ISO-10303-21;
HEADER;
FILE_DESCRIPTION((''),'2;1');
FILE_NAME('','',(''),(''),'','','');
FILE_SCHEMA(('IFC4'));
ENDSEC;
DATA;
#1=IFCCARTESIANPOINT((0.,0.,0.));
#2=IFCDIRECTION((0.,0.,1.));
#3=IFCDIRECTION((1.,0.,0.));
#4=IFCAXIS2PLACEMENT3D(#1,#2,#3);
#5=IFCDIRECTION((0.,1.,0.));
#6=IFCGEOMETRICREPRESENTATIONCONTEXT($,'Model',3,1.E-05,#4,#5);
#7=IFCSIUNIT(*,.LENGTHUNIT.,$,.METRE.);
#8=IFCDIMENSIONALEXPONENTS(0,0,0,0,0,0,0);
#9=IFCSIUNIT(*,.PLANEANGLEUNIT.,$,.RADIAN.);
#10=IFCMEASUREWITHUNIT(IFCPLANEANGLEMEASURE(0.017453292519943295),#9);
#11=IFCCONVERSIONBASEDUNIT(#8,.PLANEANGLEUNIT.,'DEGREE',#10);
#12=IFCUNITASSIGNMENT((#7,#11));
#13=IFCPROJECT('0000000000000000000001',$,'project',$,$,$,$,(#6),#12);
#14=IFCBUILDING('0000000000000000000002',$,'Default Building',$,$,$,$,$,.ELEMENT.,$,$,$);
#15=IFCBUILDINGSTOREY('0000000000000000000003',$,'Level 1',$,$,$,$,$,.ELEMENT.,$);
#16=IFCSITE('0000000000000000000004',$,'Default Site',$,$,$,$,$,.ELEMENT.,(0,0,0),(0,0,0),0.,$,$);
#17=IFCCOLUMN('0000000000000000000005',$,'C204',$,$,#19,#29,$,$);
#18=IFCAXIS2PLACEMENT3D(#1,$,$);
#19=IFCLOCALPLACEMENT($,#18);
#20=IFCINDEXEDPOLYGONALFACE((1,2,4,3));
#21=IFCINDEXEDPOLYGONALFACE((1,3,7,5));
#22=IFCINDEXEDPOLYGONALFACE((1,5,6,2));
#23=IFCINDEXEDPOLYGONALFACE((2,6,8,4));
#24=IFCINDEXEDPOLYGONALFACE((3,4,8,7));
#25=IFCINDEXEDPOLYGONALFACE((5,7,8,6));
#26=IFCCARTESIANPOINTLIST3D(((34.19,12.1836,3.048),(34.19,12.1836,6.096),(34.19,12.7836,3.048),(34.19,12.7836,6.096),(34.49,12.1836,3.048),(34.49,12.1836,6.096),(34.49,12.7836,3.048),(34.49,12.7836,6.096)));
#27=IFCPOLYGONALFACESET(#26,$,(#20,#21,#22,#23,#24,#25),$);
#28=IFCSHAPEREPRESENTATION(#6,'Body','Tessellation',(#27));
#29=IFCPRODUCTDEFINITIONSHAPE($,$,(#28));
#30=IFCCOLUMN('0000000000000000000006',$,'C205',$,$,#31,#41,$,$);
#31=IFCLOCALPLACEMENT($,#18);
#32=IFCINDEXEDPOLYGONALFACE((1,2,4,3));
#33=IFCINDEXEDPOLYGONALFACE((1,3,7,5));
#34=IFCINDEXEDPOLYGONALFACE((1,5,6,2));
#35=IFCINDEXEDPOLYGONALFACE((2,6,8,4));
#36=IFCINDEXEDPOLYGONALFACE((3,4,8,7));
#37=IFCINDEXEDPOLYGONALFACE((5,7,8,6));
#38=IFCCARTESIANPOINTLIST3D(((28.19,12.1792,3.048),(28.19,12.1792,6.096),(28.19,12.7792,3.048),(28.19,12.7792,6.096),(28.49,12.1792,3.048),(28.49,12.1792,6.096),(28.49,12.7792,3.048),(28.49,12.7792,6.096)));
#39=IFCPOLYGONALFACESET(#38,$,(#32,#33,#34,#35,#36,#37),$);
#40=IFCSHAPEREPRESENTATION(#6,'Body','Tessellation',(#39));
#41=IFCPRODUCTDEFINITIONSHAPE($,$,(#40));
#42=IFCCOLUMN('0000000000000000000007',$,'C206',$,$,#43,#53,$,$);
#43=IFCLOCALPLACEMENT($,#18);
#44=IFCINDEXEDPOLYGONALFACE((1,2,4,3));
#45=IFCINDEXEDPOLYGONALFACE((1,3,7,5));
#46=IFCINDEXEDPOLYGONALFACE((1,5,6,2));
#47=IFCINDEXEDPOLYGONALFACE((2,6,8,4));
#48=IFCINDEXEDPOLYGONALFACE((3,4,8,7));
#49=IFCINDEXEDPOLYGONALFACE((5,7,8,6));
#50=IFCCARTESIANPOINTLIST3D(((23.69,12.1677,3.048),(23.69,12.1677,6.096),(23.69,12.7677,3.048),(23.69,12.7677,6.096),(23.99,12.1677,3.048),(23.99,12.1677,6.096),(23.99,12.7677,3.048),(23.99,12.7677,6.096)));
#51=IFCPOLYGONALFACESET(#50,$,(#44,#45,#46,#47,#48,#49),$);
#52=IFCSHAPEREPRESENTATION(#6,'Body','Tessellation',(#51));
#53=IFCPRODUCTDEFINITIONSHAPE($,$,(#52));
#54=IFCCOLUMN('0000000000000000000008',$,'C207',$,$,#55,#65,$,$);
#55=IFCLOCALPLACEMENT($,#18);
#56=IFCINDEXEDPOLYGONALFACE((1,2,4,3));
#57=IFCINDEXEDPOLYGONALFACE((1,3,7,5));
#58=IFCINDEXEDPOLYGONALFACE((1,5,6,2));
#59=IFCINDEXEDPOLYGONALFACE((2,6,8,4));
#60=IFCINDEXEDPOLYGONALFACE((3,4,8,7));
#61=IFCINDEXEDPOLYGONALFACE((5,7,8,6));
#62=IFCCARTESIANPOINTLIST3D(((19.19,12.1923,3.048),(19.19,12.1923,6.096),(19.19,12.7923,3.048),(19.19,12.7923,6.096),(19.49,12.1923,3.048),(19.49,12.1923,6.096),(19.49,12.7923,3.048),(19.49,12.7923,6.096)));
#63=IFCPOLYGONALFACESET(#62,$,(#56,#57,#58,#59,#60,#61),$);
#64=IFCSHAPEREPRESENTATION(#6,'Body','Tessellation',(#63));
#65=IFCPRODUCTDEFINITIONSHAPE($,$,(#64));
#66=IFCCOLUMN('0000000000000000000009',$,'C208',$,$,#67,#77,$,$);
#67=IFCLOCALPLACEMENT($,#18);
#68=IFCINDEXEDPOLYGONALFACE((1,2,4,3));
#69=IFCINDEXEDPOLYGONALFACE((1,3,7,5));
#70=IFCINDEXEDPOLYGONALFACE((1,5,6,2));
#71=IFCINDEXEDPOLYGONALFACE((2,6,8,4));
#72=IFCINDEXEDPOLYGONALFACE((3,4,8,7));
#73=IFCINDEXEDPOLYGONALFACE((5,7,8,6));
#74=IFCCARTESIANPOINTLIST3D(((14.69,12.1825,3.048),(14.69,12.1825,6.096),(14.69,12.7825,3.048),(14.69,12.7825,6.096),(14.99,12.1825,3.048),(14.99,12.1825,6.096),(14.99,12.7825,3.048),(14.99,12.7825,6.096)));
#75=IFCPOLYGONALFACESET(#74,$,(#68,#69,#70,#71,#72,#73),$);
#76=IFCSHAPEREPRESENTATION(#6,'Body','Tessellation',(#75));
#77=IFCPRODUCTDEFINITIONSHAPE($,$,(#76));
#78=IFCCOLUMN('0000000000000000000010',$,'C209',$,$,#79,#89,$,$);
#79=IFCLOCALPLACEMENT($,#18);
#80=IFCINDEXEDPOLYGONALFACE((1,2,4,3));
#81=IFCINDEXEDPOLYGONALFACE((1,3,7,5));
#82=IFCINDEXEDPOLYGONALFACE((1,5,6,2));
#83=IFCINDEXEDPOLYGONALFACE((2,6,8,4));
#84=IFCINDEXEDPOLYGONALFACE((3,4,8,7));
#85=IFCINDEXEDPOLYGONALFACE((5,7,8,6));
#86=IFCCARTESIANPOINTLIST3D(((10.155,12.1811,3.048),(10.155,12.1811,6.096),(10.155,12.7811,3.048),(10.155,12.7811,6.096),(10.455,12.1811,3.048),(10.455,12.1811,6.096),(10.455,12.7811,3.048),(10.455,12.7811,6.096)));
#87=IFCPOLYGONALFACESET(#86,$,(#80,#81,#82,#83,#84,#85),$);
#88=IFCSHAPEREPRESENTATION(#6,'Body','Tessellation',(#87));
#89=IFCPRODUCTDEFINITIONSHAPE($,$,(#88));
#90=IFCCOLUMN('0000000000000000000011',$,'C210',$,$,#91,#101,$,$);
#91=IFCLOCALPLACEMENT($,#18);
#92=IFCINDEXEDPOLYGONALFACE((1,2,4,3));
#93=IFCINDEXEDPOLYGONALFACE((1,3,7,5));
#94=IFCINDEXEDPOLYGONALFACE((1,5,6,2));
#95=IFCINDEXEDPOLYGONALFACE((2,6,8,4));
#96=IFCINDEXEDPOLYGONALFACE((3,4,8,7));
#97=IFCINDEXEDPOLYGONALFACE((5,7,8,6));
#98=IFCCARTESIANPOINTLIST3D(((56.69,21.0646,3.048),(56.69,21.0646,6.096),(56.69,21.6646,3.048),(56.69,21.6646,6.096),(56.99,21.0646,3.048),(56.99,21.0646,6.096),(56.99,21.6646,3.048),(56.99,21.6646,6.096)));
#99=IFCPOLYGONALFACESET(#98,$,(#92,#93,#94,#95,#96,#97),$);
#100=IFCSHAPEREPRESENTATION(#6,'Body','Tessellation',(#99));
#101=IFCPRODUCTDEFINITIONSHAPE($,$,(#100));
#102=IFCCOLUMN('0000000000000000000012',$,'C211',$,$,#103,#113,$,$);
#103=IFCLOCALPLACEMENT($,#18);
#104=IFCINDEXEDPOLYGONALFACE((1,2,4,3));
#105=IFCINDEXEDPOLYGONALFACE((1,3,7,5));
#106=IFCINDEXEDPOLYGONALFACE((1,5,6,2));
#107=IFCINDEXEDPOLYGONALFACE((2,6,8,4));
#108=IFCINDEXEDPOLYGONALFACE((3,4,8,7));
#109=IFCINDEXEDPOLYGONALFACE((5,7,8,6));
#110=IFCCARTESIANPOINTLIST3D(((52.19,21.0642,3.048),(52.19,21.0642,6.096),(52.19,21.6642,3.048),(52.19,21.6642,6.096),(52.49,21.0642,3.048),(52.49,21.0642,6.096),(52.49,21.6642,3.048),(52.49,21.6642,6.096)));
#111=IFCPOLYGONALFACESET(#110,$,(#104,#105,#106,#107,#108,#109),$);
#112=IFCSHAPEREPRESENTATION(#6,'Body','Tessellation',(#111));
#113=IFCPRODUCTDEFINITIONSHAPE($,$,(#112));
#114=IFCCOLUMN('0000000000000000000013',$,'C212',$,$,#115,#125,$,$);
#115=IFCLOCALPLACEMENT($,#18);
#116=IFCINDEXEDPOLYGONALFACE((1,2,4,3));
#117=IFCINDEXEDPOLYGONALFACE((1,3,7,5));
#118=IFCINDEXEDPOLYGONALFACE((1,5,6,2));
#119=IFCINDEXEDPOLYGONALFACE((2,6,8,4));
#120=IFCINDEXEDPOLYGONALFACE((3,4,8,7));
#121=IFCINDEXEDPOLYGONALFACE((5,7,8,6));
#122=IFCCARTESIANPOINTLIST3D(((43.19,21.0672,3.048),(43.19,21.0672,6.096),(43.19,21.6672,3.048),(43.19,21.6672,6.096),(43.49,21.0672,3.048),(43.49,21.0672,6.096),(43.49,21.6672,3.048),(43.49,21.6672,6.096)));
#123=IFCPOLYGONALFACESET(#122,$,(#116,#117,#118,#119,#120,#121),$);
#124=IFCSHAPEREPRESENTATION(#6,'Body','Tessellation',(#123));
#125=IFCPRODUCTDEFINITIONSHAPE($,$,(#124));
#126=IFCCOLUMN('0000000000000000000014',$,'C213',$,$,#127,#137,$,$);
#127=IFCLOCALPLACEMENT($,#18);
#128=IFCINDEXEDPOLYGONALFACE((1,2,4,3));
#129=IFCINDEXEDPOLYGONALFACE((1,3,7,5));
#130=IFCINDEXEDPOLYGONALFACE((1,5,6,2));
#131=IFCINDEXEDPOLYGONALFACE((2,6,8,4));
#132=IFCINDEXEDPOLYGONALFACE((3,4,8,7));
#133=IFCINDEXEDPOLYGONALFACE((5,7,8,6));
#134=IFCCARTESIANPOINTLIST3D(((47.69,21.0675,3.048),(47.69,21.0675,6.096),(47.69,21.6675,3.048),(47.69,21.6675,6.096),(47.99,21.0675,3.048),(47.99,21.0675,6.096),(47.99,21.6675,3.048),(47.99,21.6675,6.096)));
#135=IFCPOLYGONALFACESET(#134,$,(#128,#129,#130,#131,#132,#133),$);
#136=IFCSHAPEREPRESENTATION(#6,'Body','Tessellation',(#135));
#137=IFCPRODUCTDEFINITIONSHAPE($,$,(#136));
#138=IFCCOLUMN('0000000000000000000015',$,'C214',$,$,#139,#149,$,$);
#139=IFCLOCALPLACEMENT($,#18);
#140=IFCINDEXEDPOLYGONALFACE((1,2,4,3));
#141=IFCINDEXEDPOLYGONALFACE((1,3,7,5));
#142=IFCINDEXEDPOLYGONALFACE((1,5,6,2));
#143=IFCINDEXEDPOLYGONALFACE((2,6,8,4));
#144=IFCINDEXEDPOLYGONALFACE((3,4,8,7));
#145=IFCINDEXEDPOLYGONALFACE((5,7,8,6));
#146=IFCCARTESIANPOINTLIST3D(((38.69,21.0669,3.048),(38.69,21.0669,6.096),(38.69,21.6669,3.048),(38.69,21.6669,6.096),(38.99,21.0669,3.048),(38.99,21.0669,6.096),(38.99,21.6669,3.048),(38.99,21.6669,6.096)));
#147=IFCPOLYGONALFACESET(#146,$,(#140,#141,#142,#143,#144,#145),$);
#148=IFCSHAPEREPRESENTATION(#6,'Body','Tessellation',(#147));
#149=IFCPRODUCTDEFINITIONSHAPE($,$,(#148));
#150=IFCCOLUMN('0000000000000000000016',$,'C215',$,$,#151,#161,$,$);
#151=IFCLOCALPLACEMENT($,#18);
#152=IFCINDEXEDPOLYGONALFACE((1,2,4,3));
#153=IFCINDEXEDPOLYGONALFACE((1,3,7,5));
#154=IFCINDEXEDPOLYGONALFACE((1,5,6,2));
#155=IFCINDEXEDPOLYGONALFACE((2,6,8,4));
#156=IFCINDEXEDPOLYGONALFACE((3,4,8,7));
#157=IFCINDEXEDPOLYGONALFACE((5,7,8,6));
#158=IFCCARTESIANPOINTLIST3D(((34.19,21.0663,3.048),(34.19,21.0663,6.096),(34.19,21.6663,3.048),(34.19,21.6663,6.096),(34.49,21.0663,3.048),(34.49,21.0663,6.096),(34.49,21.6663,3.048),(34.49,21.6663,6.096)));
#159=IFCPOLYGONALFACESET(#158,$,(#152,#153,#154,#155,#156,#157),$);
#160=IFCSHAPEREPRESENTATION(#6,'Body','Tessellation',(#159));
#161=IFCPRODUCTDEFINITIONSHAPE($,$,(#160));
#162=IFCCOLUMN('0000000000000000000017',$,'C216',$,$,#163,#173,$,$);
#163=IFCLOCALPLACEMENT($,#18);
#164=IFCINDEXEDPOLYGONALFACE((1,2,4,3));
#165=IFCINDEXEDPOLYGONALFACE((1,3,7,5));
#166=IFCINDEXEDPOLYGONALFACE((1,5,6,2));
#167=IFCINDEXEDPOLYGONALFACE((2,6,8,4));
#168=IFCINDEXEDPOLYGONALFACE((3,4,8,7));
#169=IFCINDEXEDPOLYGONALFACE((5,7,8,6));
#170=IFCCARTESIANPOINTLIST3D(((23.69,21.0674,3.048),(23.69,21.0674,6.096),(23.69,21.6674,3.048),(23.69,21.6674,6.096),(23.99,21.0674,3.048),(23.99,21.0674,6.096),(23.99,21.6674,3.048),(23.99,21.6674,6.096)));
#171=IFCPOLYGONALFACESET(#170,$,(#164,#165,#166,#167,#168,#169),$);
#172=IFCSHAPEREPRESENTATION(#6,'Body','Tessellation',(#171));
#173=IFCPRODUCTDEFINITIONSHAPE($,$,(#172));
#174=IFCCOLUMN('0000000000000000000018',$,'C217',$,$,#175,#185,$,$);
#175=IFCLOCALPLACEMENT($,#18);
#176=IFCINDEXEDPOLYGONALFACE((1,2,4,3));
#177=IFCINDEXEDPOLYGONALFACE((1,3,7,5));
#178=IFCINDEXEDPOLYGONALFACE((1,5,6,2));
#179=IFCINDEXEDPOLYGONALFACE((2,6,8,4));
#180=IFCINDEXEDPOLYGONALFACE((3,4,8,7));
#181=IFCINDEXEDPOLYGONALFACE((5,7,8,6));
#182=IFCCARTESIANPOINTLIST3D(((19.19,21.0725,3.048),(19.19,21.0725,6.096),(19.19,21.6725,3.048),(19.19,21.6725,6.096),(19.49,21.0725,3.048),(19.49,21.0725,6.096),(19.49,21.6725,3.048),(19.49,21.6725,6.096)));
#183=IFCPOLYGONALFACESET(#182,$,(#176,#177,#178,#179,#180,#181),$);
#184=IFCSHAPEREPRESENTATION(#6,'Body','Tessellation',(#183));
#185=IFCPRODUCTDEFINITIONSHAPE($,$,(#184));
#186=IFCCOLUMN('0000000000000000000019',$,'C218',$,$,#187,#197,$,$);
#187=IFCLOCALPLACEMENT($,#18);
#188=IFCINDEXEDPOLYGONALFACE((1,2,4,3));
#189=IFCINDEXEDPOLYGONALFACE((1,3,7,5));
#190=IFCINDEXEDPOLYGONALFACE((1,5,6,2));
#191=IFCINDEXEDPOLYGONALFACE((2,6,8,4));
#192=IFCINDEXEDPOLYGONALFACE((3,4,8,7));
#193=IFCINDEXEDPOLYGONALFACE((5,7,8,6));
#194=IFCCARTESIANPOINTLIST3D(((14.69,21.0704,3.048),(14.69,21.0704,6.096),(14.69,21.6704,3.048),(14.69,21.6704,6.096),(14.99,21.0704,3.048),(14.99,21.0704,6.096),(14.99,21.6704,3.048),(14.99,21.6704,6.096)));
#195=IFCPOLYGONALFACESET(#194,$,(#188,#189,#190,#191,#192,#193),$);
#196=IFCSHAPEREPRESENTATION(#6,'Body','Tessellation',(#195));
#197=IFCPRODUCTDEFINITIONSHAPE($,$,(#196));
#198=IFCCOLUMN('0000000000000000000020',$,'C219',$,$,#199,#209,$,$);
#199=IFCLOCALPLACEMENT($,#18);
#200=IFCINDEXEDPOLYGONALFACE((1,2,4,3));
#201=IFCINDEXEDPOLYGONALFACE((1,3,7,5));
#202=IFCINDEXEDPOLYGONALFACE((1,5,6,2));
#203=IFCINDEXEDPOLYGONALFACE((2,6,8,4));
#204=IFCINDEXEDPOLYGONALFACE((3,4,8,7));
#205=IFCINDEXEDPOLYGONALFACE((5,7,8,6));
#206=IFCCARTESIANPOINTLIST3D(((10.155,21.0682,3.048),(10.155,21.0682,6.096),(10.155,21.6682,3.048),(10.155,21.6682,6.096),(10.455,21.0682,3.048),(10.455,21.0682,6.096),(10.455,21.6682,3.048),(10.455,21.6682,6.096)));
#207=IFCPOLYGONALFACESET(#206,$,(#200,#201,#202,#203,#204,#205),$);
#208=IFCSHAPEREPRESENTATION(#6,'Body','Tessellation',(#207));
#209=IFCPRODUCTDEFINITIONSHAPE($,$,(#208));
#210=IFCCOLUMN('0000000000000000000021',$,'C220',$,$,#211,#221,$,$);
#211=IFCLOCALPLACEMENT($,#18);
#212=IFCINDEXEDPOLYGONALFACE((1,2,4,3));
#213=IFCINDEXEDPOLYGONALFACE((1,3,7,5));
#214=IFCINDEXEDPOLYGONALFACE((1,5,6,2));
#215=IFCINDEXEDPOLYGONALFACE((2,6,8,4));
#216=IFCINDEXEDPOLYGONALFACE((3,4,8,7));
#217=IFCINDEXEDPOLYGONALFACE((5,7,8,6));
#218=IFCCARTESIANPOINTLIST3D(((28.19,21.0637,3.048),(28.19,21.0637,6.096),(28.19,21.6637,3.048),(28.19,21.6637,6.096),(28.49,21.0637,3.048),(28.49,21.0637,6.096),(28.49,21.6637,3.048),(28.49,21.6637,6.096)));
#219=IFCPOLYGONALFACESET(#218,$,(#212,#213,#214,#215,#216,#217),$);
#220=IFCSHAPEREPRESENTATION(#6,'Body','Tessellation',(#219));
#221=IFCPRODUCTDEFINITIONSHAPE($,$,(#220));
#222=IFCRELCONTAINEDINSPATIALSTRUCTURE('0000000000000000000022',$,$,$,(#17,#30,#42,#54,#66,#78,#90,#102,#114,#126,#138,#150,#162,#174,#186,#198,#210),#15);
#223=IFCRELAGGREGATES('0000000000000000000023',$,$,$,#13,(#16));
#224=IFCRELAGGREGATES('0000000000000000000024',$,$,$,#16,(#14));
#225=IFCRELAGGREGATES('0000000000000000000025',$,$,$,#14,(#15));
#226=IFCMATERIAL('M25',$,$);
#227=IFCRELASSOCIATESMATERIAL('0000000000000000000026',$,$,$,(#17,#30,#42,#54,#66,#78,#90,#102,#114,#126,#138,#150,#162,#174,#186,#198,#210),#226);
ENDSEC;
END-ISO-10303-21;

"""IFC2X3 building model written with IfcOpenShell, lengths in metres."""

from ifc_helpers import new_model, entity, si_unit, converted_unit, direction, frame, frame_2d, origin_with_axes, place, context, project, spatial, rectangle, extrude, material, element, save


model = new_model("IFC2X3")

# Units and contexts
model_context = context("Model", 3, precision=1e-05, world=origin_with_axes(), true_north=direction((0.0, 1.0, 0.0)))
ifc_project = project(units=[si_unit("LENGTHUNIT", "METRE"), converted_unit("PLANEANGLEUNIT", "DEGREE", entity("IfcPlaneAngleMeasure", 0.017453292519943295), si_unit("PLANEANGLEUNIT", "RADIAN"), dimensions=[0, 0, 0, 0, 0, 0, 0])], contexts=[model_context])

# Site, building, storey
site = spatial("IfcSite", under=ifc_project, Name="Default Site", CompositionType="ELEMENT", RefLatitude=(0, 0, 0), RefLongitude=(0, 0, 0), RefElevation=0.0)
building = spatial("IfcBuilding", under=site, Name="Default Building", CompositionType="ELEMENT")
storey = spatial("IfcBuildingStorey", under=building, Name="Level 1", CompositionType="ELEMENT")

# Columns
ifc_material = material(Name="M25")
placement = place(None, origin_with_axes())
element("IfcColumn", 1, at=placement, inside=storey, material=ifc_material, Name="C204", context=model_context, shape_type="SweptSolid", body=[
    extrude(rectangle(XDim=0.3, YDim=0.6, at=frame_2d((0.0, 0.0), x_axis=(1.0, 0.0, 0.0))), frame((34.34, 12.4836, 3.048), z_axis=(0.0, 0.0, 1.0), x_axis=(1.0, 0.0, 0.0)), (0.0, 0.0, 1.0), 3.048),
])
element("IfcColumn", 2, at=placement, inside=storey, material=ifc_material, Name="C205", context=model_context, shape_type="SweptSolid", body=[
    extrude(rectangle(XDim=0.3, YDim=0.6, at=frame_2d((0.0, 0.0), x_axis=(1.0, 0.0, 0.0))), frame((28.34, 12.4792, 3.048), z_axis=(0.0, 0.0, 1.0), x_axis=(1.0, 0.0, 0.0)), (0.0, 0.0, 1.0), 3.048),
])
element("IfcColumn", 3, at=placement, inside=storey, material=ifc_material, Name="C206", context=model_context, shape_type="SweptSolid", body=[
    extrude(rectangle(XDim=0.3, YDim=0.6, at=frame_2d((0.0, 0.0), x_axis=(1.0, 0.0, 0.0))), frame((23.84, 12.4677, 3.048), z_axis=(0.0, 0.0, 1.0), x_axis=(1.0, 0.0, 0.0)), (0.0, 0.0, 1.0), 3.048),
])
element("IfcColumn", 4, at=placement, inside=storey, material=ifc_material, Name="C207", context=model_context, shape_type="SweptSolid", body=[
    extrude(rectangle(XDim=0.3, YDim=0.6, at=frame_2d((0.0, 0.0), x_axis=(1.0, 0.0, 0.0))), frame((19.34, 12.4923, 3.048), z_axis=(0.0, 0.0, 1.0), x_axis=(1.0, 0.0, 0.0)), (0.0, 0.0, 1.0), 3.048),
])
element("IfcColumn", 5, at=placement, inside=storey, material=ifc_material, Name="C208", context=model_context, shape_type="SweptSolid", body=[
    extrude(rectangle(XDim=0.3, YDim=0.6, at=frame_2d((0.0, 0.0), x_axis=(1.0, 0.0, 0.0))), frame((14.84, 12.4825, 3.048), z_axis=(0.0, 0.0, 1.0), x_axis=(1.0, 0.0, 0.0)), (0.0, 0.0, 1.0), 3.048),
])
element("IfcColumn", 6, at=placement, inside=storey, material=ifc_material, Name="C209", context=model_context, shape_type="SweptSolid", body=[
    extrude(rectangle(XDim=0.3, YDim=0.6, at=frame_2d((0.0, 0.0), x_axis=(1.0, 0.0, 0.0))), frame((10.305, 12.4811, 3.048), z_axis=(0.0, 0.0, 1.0), x_axis=(1.0, 0.0, 0.0)), (0.0, 0.0, 1.0), 3.048),
])
element("IfcColumn", 7, at=placement, inside=storey, material=ifc_material, Name="C210", context=model_context, shape_type="SweptSolid", body=[
    extrude(rectangle(XDim=0.3, YDim=0.6, at=frame_2d((0.0, 0.0), x_axis=(1.0, 0.0, 0.0))), frame((56.84, 21.3646, 3.048), z_axis=(0.0, 0.0, 1.0), x_axis=(1.0, 0.0, 0.0)), (0.0, 0.0, 1.0), 3.048),
])
element("IfcColumn", 8, at=placement, inside=storey, material=ifc_material, Name="C211", context=model_context, shape_type="SweptSolid", body=[
    extrude(rectangle(XDim=0.3, YDim=0.6, at=frame_2d((0.0, 0.0), x_axis=(1.0, 0.0, 0.0))), frame((52.34, 21.3642, 3.048), z_axis=(0.0, 0.0, 1.0), x_axis=(1.0, 0.0, 0.0)), (0.0, 0.0, 1.0), 3.048),
])
element("IfcColumn", 9, at=placement, inside=storey, material=ifc_material, Name="C212", context=model_context, shape_type="SweptSolid", body=[
    extrude(rectangle(XDim=0.3, YDim=0.6, at=frame_2d((0.0, 0.0), x_axis=(1.0, 0.0, 0.0))), frame((43.34, 21.3672, 3.048), z_axis=(0.0, 0.0, 1.0), x_axis=(1.0, 0.0, 0.0)), (0.0, 0.0, 1.0), 3.048),
])
element("IfcColumn", 10, at=placement, inside=storey, material=ifc_material, Name="C213", context=model_context, shape_type="SweptSolid", body=[
    extrude(rectangle(XDim=0.3, YDim=0.6, at=frame_2d((0.0, 0.0), x_axis=(1.0, 0.0, 0.0))), frame((47.84, 21.3675, 3.048), z_axis=(0.0, 0.0, 1.0), x_axis=(1.0, 0.0, 0.0)), (0.0, 0.0, 1.0), 3.048),
])
element("IfcColumn", 11, at=placement, inside=storey, material=ifc_material, Name="C214", context=model_context, shape_type="SweptSolid", body=[
    extrude(rectangle(XDim=0.3, YDim=0.6, at=frame_2d((0.0, 0.0), x_axis=(1.0, 0.0, 0.0))), frame((38.84, 21.3669, 3.048), z_axis=(0.0, 0.0, 1.0), x_axis=(1.0, 0.0, 0.0)), (0.0, 0.0, 1.0), 3.048),
])
element("IfcColumn", 12, at=placement, inside=storey, material=ifc_material, Name="C215", context=model_context, shape_type="SweptSolid", body=[
    extrude(rectangle(XDim=0.3, YDim=0.6, at=frame_2d((0.0, 0.0), x_axis=(1.0, 0.0, 0.0))), frame((34.34, 21.3663, 3.048), z_axis=(0.0, 0.0, 1.0), x_axis=(1.0, 0.0, 0.0)), (0.0, 0.0, 1.0), 3.048),
])
element("IfcColumn", 13, at=placement, inside=storey, material=ifc_material, Name="C216", context=model_context, shape_type="SweptSolid", body=[
    extrude(rectangle(XDim=0.3, YDim=0.6, at=frame_2d((0.0, 0.0), x_axis=(1.0, 0.0, 0.0))), frame((23.84, 21.3674, 3.048), z_axis=(0.0, 0.0, 1.0), x_axis=(1.0, 0.0, 0.0)), (0.0, 0.0, 1.0), 3.048),
])
element("IfcColumn", 14, at=placement, inside=storey, material=ifc_material, Name="C217", context=model_context, shape_type="SweptSolid", body=[
    extrude(rectangle(XDim=0.3, YDim=0.6, at=frame_2d((0.0, 0.0), x_axis=(1.0, 0.0, 0.0))), frame((19.34, 21.3725, 3.048), z_axis=(0.0, 0.0, 1.0), x_axis=(1.0, 0.0, 0.0)), (0.0, 0.0, 1.0), 3.048),
])
element("IfcColumn", 15, at=placement, inside=storey, material=ifc_material, Name="C218", context=model_context, shape_type="SweptSolid", body=[
    extrude(rectangle(XDim=0.3, YDim=0.6, at=frame_2d((0.0, 0.0), x_axis=(1.0, 0.0, 0.0))), frame((14.84, 21.3704, 3.048), z_axis=(0.0, 0.0, 1.0), x_axis=(1.0, 0.0, 0.0)), (0.0, 0.0, 1.0), 3.048),
])
element("IfcColumn", 16, at=placement, inside=storey, material=ifc_material, Name="C219", context=model_context, shape_type="SweptSolid", body=[
    extrude(rectangle(XDim=0.3, YDim=0.6, at=frame_2d((0.0, 0.0), x_axis=(1.0, 0.0, 0.0))), frame((10.305, 21.3682, 3.048), z_axis=(0.0, 0.0, 1.0), x_axis=(1.0, 0.0, 0.0)), (0.0, 0.0, 1.0), 3.048),
])
element("IfcColumn", 17, at=placement, inside=storey, material=ifc_material, Name="C220", context=model_context, shape_type="SweptSolid", body=[
    extrude(rectangle(XDim=0.3, YDim=0.6, at=frame_2d((0.0, 0.0), x_axis=(1.0, 0.0, 0.0))), frame((28.34, 21.3637, 3.048), z_axis=(0.0, 0.0, 1.0), x_axis=(1.0, 0.0, 0.0)), (0.0, 0.0, 1.0), 3.048),
])

save(model, "model.ifc")
